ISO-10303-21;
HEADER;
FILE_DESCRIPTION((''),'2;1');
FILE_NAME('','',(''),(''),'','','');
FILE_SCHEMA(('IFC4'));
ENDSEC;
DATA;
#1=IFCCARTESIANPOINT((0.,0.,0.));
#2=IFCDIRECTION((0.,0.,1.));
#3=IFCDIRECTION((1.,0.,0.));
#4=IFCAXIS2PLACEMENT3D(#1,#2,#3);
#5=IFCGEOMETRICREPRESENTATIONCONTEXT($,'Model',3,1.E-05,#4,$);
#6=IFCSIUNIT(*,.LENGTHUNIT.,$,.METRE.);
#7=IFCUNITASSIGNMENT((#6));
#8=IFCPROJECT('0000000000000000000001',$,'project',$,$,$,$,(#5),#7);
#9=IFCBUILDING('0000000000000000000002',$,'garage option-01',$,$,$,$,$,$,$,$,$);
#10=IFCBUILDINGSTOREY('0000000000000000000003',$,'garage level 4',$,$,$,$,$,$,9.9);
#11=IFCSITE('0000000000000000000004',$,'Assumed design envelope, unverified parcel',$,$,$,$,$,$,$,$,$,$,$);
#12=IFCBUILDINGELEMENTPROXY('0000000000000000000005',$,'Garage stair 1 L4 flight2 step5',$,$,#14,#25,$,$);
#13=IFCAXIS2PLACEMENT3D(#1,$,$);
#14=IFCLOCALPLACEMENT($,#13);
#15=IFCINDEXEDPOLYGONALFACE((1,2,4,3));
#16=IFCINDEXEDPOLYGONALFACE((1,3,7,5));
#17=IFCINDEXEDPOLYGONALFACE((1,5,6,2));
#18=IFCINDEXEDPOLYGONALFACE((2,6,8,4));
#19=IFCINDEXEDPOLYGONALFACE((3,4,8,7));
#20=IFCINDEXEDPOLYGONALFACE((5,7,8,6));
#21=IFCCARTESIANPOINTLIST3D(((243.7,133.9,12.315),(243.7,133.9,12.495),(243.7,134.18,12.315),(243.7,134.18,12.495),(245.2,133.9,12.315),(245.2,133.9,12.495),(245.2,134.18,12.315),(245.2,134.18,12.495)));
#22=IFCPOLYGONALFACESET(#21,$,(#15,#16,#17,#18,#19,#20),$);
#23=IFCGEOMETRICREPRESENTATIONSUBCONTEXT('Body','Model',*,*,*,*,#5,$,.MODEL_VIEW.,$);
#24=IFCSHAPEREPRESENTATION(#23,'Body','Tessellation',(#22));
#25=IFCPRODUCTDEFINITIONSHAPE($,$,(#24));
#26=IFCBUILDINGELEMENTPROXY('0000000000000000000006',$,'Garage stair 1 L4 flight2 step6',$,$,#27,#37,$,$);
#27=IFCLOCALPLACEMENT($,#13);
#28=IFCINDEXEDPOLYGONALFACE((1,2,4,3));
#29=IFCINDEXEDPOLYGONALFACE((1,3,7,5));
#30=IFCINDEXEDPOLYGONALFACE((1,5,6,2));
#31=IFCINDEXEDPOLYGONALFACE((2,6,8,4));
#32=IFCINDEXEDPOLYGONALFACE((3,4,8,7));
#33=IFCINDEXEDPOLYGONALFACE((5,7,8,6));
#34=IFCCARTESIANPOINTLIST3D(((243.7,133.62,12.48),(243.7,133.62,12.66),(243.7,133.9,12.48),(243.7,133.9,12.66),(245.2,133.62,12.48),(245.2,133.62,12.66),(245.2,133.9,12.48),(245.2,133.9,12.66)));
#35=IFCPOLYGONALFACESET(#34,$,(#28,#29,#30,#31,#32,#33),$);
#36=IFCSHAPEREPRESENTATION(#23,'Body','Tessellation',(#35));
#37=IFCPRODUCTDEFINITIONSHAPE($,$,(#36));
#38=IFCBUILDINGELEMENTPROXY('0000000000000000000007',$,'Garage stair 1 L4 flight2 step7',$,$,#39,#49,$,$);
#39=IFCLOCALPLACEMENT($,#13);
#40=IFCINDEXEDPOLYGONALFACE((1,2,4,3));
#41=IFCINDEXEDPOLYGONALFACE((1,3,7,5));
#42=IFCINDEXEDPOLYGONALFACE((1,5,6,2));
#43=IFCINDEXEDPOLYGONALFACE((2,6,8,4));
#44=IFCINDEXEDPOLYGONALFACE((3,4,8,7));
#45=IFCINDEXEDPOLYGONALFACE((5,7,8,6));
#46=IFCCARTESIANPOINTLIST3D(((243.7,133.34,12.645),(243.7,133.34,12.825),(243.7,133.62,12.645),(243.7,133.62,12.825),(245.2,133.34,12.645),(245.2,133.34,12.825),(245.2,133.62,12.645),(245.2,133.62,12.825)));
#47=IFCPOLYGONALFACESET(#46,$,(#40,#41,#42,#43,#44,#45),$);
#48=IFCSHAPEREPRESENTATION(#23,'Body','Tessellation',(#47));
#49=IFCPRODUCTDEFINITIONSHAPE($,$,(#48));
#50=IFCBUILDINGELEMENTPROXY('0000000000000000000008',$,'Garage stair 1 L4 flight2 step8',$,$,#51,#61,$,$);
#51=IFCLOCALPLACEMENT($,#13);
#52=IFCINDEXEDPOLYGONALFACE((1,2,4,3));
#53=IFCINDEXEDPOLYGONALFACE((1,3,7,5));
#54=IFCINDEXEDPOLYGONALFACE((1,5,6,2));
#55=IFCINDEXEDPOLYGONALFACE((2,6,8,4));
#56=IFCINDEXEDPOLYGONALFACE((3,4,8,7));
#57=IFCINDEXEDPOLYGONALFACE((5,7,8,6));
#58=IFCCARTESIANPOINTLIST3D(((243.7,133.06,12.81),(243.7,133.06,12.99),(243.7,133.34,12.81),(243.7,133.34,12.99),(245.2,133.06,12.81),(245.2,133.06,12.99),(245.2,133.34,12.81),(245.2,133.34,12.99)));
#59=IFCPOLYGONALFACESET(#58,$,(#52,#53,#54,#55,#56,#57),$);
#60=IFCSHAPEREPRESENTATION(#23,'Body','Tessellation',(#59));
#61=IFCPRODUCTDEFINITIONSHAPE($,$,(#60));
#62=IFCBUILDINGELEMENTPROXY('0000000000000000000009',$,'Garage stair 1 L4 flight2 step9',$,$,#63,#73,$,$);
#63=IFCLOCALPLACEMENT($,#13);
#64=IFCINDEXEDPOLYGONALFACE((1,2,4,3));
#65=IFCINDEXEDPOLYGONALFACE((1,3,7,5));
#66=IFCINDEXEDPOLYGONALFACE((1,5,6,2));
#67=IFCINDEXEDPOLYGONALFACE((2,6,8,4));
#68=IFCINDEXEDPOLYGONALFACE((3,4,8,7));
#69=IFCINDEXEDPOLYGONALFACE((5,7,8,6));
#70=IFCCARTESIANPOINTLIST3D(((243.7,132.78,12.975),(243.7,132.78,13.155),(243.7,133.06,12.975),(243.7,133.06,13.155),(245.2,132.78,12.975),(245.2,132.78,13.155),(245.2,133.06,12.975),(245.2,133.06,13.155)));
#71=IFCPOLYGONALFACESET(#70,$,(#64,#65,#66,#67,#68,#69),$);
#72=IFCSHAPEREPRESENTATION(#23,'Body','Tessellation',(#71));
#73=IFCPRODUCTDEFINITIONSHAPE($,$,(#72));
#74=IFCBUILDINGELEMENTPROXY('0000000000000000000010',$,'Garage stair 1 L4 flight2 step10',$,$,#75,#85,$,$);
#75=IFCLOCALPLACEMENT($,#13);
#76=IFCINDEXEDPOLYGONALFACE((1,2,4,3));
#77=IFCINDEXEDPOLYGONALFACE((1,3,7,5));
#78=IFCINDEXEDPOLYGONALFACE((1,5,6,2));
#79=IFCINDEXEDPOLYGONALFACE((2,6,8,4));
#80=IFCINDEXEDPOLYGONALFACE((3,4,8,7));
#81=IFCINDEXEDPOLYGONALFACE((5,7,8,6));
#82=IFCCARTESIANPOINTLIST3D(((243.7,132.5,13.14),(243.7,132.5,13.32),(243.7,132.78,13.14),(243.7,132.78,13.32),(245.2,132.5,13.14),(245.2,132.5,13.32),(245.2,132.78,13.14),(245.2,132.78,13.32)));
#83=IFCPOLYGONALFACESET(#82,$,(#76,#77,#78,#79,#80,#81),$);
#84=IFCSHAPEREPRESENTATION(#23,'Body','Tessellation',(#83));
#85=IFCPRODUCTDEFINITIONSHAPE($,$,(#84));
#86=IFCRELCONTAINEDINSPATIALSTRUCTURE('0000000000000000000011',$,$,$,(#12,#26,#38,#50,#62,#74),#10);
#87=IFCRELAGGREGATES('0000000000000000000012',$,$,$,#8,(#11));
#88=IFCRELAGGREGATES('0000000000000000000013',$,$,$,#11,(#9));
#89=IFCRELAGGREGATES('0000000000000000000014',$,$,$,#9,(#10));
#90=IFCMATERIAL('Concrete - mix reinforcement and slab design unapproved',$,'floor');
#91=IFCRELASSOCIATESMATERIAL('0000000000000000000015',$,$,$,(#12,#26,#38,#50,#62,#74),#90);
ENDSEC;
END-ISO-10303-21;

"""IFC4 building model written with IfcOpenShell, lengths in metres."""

from ifc_helpers import new_model, si_unit, frame, origin_with_axes, place, context, subcontext, project, spatial, rectangle, extrude, material, element, save


model = new_model("IFC4")

# Units and contexts
model_context = context("Model", 3, precision=1e-05, world=origin_with_axes())
body_context = subcontext(model_context, "Body", "Model", "MODEL_VIEW")
ifc_project = project(units=[si_unit("LENGTHUNIT", "METRE")], contexts=[model_context])

# Site, building, storey
site = spatial("IfcSite", under=ifc_project, Name="Assumed design envelope, unverified parcel")
building = spatial("IfcBuilding", under=site, Name="garage option-01")
storey = spatial("IfcBuildingStorey", under=building, Name="garage level 4", Elevation=9.9)

# Shared definitions
ifc_material_1 = material(Name="Concrete - mix reinforcement and slab design unapproved", Category="floor")

# Building element proxies
for number, where, z_axis, x_axis, name in (
    (1, (244.45, 134.04, 12.315), (0.0, 0.0, 1.0), (1.0, 0.0, 0.0), "Garage stair 1 L4 flight2 step5"),
    (2, (244.45, 133.76, 12.48), (0.0, 0.0, 1.0), (1.0, 0.0, 0.0), "Garage stair 1 L4 flight2 step6"),
    (3, (244.45, 133.48, 12.645), (0.0, 0.0, 1.0), (1.0, 0.0, 0.0), "Garage stair 1 L4 flight2 step7"),
    (4, (244.45, 133.2, 12.81), (0.0, 0.0, 1.0), (1.0, 0.0, 0.0), "Garage stair 1 L4 flight2 step8"),
    (5, (244.45, 132.92, 12.975), (0.0, 0.0, 1.0), (1.0, 0.0, 0.0), "Garage stair 1 L4 flight2 step9"),
    (6, (244.45, 132.64, 13.14), (0.0, 0.0, 1.0), (1.0, 0.0, 0.0), "Garage stair 1 L4 flight2 step10"),
):
    element("IfcBuildingElementProxy", number, at=place(None, frame(where, z_axis=z_axis, x_axis=x_axis)), inside=storey, material=ifc_material_1, Name=name, context=body_context, shape_type="SweptSolid", body=[
        extrude(rectangle(XDim=1.5, YDim=0.28), origin_with_axes(), (0.0, 0.0, 1.0), 0.18),
    ])

save(model, "model.ifc")
